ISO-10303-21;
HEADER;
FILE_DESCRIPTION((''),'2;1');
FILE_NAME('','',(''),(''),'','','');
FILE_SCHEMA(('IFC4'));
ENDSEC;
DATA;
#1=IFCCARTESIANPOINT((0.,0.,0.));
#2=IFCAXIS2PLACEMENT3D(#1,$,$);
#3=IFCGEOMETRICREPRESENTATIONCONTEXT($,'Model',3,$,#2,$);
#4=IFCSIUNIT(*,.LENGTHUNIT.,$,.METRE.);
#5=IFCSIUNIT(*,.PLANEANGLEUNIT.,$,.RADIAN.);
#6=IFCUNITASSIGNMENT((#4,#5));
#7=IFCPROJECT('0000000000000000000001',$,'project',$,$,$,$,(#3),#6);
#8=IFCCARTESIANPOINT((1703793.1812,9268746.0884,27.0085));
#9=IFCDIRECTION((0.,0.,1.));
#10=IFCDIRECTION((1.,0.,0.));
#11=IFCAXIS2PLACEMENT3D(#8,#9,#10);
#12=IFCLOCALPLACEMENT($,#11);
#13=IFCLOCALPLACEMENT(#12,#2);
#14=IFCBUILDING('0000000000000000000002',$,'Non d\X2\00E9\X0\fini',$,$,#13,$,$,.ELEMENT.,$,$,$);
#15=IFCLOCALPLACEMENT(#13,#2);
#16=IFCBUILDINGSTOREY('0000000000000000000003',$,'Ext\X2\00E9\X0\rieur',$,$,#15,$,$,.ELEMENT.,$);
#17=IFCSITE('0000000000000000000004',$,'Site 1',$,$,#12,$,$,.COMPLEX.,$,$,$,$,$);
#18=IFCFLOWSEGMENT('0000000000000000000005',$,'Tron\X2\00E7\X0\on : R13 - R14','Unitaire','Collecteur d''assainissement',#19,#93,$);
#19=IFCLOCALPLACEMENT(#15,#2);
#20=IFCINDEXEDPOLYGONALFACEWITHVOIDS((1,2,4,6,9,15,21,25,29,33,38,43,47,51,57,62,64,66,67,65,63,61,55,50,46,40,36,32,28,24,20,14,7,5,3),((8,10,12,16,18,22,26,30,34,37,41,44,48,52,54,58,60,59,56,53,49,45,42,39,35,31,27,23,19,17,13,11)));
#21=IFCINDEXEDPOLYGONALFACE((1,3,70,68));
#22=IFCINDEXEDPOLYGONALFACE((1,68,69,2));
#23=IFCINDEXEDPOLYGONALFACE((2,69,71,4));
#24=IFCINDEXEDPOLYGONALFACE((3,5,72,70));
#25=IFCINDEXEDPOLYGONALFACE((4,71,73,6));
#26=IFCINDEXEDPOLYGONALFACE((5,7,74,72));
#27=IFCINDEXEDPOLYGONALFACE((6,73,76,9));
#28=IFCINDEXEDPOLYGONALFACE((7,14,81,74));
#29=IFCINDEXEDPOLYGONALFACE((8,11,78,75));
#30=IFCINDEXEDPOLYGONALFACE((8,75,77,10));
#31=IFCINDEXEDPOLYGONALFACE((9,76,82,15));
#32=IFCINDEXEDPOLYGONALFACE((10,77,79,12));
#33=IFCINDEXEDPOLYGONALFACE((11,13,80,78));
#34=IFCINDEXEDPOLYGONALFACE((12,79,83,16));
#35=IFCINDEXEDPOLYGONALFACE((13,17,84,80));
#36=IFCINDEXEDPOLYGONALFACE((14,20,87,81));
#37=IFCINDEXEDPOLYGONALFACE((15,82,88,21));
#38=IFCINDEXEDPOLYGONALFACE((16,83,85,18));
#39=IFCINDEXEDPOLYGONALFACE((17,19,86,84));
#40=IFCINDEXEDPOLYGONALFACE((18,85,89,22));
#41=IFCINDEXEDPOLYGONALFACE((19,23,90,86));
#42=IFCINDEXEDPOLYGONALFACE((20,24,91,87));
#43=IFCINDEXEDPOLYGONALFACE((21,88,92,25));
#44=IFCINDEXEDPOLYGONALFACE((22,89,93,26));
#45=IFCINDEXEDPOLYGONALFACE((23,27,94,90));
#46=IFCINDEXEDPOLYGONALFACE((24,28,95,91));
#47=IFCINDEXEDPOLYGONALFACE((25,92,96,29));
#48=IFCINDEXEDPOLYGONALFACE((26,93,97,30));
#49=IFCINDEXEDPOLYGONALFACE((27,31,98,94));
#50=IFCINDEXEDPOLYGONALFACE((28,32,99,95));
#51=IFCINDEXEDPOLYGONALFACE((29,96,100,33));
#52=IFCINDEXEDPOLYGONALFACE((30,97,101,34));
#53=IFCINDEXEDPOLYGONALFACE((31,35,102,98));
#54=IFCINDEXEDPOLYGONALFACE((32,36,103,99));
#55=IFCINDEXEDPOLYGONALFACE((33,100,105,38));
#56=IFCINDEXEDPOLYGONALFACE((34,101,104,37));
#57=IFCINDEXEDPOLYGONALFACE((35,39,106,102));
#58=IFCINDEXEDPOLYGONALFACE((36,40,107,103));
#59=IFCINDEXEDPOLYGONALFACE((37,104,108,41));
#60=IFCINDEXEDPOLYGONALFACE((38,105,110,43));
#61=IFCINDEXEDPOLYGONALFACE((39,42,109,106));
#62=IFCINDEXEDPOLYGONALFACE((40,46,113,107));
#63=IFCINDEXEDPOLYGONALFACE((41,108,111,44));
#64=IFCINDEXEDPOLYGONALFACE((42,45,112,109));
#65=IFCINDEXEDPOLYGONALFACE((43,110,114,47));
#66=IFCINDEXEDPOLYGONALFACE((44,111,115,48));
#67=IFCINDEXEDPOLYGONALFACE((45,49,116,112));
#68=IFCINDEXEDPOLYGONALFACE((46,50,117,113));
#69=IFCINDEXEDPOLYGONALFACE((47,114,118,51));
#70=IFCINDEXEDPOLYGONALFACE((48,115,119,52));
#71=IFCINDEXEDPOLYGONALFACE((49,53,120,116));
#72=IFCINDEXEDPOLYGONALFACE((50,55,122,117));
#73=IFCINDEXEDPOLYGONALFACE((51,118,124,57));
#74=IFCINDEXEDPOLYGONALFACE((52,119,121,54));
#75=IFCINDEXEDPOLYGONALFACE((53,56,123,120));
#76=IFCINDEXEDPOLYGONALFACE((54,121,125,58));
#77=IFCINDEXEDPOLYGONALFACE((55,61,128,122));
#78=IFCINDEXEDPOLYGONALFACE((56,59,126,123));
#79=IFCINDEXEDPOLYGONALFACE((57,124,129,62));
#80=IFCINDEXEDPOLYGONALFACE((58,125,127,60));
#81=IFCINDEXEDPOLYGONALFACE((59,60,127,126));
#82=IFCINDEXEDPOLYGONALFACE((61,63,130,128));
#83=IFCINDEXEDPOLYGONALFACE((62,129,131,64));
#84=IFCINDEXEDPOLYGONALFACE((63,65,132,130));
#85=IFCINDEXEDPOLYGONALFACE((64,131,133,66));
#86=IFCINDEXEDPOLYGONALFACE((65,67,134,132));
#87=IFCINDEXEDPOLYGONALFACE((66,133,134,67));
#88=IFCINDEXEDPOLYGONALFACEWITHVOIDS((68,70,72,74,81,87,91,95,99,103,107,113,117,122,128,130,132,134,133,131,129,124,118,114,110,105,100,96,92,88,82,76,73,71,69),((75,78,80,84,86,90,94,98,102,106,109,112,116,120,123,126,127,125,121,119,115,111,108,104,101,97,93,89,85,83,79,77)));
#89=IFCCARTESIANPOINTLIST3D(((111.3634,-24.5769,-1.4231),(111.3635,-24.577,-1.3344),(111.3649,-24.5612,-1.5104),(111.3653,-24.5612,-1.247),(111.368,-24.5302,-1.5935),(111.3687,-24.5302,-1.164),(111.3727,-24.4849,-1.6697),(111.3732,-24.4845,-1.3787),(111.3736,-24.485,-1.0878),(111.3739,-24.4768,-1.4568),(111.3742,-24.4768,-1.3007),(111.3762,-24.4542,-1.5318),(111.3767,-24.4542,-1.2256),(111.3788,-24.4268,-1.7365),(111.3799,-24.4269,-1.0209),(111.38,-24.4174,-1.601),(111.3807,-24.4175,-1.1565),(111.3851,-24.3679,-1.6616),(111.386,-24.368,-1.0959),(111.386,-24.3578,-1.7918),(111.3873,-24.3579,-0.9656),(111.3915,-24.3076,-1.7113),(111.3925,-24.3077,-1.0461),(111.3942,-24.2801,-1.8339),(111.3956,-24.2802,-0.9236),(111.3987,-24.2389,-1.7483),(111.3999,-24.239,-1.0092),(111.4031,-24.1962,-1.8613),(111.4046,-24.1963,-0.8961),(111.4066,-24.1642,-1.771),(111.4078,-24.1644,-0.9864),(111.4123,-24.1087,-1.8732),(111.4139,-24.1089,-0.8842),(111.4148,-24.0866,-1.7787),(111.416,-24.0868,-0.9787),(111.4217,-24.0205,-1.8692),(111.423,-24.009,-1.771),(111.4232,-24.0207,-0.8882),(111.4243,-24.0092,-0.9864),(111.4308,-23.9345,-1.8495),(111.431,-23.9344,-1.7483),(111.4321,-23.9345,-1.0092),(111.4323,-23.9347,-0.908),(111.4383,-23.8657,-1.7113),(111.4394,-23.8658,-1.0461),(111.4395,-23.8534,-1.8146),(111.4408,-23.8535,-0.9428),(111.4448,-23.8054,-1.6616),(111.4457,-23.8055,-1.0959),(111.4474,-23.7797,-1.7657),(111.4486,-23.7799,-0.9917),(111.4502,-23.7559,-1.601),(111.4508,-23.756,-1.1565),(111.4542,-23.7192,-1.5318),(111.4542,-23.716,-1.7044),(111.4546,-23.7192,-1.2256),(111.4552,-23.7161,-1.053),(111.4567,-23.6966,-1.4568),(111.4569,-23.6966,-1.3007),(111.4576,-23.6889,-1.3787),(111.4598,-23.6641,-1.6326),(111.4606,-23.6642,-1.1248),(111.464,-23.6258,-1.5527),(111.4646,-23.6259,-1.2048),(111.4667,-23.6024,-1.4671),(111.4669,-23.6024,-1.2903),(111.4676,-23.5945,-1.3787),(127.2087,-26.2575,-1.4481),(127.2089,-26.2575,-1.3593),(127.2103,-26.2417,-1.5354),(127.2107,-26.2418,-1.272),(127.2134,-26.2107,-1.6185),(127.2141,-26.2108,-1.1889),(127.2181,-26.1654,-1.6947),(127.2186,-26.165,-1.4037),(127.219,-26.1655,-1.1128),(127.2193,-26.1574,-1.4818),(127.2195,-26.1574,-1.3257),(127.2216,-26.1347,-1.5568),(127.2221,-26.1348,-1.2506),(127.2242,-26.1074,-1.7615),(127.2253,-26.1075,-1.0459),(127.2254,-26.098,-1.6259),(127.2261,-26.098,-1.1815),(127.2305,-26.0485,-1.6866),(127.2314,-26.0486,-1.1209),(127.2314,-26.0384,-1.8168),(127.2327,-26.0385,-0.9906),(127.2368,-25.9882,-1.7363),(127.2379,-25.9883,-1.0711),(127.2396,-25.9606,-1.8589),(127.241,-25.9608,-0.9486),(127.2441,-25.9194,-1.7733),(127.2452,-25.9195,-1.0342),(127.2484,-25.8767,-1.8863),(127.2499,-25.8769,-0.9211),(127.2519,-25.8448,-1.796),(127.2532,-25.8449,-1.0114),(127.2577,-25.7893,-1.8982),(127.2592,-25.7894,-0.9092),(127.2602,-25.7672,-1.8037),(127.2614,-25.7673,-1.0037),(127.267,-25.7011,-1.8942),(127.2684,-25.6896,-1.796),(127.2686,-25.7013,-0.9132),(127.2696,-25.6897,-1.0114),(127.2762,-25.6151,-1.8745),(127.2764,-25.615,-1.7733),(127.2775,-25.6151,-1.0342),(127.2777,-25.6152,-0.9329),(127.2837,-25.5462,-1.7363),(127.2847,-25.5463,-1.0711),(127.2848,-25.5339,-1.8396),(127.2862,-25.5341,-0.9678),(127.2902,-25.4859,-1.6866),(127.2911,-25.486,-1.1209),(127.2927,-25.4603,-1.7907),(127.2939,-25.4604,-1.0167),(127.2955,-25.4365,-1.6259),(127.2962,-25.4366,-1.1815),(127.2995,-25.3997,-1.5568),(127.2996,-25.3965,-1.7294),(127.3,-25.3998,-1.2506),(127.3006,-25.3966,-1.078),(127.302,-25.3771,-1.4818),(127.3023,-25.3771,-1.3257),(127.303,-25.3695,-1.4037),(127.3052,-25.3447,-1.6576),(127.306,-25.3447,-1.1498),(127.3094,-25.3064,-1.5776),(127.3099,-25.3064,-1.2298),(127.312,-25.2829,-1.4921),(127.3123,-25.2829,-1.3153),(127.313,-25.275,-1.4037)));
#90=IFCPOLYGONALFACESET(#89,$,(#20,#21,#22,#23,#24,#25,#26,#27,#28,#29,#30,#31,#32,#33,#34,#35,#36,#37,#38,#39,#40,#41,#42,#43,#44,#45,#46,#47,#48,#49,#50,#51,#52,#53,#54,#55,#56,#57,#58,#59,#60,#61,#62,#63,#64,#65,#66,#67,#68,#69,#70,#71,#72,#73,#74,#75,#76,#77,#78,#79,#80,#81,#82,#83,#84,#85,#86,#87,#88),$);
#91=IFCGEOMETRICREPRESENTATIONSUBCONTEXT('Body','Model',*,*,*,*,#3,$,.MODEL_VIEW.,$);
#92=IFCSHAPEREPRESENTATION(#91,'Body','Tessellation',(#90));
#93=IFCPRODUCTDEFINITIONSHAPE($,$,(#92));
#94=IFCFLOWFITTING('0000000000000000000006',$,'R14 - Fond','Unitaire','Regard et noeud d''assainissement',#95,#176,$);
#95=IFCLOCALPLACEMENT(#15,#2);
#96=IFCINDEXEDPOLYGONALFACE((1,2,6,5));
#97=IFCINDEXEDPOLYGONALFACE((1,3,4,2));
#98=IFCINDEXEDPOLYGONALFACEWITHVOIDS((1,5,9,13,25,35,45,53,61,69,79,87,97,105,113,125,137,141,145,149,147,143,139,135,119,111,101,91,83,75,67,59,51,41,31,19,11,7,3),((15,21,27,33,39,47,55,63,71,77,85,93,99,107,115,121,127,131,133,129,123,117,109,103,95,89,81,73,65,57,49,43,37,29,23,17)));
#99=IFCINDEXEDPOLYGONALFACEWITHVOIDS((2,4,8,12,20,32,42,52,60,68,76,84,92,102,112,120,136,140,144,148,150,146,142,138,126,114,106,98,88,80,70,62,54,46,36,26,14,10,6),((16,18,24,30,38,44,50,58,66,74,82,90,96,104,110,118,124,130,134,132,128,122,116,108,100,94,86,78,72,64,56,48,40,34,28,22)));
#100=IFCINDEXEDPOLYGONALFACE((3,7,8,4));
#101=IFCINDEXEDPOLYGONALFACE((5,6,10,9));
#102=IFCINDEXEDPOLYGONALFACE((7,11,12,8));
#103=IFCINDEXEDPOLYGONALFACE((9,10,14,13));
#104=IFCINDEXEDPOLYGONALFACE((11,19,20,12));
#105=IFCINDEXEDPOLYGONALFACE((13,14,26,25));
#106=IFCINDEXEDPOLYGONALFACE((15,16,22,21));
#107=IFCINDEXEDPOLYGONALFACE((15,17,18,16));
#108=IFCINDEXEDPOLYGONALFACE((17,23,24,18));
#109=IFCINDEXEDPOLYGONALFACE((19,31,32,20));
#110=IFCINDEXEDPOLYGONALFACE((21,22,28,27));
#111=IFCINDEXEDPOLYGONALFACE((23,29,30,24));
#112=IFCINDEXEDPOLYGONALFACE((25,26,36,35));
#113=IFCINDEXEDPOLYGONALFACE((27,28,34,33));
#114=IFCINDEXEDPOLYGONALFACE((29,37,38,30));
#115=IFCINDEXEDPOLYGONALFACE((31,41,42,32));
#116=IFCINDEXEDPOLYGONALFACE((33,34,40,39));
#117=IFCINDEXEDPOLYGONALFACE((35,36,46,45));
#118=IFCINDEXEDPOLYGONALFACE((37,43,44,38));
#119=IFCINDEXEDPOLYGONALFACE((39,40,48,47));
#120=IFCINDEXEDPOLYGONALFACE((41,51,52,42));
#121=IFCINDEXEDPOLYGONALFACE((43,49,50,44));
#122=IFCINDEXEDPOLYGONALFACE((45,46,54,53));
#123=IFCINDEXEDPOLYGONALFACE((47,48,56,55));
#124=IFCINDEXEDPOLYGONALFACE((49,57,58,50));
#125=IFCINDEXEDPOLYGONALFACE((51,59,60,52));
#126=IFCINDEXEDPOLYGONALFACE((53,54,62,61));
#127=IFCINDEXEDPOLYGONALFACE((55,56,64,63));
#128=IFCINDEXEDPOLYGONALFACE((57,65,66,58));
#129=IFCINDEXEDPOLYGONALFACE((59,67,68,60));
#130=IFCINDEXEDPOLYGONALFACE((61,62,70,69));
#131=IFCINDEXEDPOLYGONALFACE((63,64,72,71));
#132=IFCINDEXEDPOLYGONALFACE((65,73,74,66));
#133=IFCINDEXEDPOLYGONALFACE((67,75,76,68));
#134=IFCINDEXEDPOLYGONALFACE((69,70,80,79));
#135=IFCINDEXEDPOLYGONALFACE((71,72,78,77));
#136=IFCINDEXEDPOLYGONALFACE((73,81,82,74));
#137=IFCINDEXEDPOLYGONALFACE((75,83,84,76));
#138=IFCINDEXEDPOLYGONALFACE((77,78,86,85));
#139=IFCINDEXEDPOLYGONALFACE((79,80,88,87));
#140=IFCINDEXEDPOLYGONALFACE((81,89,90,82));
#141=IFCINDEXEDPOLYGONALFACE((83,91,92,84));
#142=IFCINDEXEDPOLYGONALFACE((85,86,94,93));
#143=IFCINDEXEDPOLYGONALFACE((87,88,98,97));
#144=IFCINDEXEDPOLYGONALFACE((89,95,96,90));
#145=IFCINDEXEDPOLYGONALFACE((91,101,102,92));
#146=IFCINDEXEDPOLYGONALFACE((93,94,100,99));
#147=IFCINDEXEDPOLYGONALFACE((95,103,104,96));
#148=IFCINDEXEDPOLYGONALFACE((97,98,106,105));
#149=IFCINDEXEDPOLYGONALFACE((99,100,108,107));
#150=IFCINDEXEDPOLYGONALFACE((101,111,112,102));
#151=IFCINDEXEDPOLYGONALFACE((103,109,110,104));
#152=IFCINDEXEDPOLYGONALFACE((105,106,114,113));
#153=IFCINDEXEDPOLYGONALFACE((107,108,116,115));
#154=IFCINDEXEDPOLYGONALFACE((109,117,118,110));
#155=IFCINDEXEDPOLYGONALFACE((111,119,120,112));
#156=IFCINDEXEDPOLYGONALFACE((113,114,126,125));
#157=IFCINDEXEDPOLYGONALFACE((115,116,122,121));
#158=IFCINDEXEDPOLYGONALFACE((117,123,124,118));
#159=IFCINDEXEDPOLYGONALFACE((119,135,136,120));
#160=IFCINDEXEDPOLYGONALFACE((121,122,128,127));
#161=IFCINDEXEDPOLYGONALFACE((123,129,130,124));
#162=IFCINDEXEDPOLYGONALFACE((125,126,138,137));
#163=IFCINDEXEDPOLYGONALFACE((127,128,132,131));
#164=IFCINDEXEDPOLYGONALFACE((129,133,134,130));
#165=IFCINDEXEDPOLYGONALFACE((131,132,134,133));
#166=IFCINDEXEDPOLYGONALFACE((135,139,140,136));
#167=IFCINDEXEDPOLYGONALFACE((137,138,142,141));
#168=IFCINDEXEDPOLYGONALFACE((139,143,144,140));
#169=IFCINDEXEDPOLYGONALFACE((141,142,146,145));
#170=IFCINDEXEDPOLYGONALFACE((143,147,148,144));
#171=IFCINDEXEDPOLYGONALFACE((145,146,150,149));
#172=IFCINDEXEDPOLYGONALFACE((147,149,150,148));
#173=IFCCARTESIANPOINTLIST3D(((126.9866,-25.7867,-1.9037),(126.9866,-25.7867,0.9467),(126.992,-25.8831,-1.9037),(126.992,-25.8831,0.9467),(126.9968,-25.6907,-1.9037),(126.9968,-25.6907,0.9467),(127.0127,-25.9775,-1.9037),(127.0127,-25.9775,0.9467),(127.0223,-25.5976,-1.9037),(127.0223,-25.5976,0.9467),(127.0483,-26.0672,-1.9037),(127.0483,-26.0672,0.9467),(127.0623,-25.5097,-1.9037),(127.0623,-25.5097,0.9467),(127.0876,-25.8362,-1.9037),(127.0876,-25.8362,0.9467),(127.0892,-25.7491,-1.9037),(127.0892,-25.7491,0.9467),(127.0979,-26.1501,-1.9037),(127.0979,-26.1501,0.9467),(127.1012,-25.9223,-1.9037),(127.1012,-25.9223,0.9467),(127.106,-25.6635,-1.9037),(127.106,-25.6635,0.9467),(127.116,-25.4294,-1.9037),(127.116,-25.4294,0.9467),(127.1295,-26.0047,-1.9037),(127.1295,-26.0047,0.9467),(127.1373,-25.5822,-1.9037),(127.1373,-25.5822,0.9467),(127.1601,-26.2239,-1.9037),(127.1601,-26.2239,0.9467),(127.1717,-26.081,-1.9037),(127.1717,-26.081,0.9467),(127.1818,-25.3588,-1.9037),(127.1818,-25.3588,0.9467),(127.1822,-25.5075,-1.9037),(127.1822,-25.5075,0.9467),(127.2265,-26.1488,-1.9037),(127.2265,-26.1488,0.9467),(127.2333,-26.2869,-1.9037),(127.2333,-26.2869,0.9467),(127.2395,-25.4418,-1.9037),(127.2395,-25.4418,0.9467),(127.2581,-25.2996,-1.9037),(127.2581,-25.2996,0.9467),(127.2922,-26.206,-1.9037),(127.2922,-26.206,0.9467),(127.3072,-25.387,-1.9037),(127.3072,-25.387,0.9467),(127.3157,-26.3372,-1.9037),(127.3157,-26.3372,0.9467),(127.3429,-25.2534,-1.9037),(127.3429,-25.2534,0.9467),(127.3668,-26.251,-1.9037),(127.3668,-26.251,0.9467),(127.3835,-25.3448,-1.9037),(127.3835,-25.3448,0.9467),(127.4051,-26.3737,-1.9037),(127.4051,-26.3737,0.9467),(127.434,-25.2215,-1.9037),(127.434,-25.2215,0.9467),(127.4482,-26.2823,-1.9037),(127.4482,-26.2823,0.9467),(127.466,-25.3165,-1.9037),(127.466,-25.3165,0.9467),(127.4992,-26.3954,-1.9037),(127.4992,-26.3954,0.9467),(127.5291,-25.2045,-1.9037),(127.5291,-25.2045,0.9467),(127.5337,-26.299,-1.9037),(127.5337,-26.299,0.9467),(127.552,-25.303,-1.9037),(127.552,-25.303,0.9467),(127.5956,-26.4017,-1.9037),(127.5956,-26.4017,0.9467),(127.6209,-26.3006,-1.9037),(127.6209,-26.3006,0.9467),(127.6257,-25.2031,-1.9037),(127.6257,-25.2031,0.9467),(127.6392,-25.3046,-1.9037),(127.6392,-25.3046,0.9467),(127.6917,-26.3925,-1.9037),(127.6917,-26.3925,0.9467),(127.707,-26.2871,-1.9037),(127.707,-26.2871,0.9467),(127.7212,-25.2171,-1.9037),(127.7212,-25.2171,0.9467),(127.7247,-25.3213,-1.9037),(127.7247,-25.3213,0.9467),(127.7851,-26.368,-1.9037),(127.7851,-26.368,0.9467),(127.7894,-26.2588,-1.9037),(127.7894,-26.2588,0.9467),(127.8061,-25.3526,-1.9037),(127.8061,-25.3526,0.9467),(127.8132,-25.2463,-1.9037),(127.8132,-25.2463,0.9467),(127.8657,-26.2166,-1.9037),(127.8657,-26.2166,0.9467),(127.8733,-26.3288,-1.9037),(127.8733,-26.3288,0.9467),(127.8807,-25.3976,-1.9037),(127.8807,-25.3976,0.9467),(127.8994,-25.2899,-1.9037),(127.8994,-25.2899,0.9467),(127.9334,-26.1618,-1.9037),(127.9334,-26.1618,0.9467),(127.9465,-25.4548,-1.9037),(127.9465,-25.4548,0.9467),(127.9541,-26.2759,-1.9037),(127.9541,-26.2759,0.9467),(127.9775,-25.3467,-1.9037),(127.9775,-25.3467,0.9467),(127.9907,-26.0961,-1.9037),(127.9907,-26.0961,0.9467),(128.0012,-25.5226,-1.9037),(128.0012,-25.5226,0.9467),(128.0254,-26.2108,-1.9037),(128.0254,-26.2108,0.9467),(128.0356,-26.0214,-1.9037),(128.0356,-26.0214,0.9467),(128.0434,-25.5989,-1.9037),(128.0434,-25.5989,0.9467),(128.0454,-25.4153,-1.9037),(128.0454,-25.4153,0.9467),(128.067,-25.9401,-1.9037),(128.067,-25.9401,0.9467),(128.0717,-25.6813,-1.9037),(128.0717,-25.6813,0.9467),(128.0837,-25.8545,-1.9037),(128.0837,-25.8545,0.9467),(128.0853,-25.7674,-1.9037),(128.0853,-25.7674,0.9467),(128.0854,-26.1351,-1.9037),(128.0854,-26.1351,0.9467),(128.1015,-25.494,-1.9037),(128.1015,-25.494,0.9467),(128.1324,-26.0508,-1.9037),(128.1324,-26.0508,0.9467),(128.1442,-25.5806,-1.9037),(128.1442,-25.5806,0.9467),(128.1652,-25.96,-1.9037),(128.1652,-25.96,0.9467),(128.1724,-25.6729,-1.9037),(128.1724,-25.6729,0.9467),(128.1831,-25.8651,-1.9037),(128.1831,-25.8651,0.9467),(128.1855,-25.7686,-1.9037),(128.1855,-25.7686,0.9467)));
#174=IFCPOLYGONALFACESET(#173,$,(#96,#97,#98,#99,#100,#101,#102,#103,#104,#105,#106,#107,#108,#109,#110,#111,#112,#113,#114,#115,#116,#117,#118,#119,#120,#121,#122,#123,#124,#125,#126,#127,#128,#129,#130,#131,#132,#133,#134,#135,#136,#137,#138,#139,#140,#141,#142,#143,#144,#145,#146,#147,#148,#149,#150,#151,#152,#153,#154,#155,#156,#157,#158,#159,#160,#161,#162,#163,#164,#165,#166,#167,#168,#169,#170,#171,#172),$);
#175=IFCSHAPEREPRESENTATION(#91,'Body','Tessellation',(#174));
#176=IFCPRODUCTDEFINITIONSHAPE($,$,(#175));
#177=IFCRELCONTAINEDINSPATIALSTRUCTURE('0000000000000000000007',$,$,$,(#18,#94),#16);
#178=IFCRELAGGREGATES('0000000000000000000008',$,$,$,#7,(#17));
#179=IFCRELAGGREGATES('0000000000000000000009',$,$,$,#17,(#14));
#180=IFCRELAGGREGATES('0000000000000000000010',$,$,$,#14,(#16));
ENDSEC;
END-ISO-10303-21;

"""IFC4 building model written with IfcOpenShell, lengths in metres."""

from ifc_helpers import new_model, si_unit, frame, origin, origin_2d, place, context, subcontext, project, spatial, hollow_circle, extrude, element, save


model = new_model("IFC4")

# Units and contexts
model_context = context("Model", 3, world=origin())
body_context = subcontext(model_context, "Body", "Model", "MODEL_VIEW")
ifc_project = project(units=[si_unit("LENGTHUNIT", "METRE"), si_unit("PLANEANGLEUNIT", "RADIAN")], contexts=[model_context])

# Site, building, storey
site_placement = place(None, frame((1703793.1812, 9268746.0884, 27.0085), z_axis=(0.0, 0.0, 1.0), x_axis=(1.0, 0.0, 0.0)))
site = spatial("IfcSite", under=ifc_project, at=site_placement, Name="Site 1", CompositionType="COMPLEX")
building_placement = place(site_placement, origin())
building = spatial("IfcBuilding", under=site, at=building_placement, Name="Non défini", CompositionType="ELEMENT")
storey_placement = place(building_placement, origin())
storey = spatial("IfcBuildingStorey", under=building, at=storey_placement, Name="Extérieur", CompositionType="ELEMENT")

# Flow segment
flow_segment_1_placement = place(storey_placement, origin())
element("IfcFlowSegment", 1, at=flow_segment_1_placement, inside=storey, Name="Tronçon : R13 - R14", Description="Unitaire", ObjectType="Collecteur d'assainissement", context=body_context, shape_type="SweptSolid", body=[
    extrude(hollow_circle(Radius=0.495, WallThickness=0.095, at=origin_2d()), frame((111.4154, -24.0867, -1.3787), z_axis=(0.994421, -0.105468, -0.001569), x_axis=(0.105469, 0.994423, 0.0)), (0.0, 0.0, 1.0), 15.9343),
])

# Flow fitting
flow_fitting_1_placement = place(storey_placement, origin())
element("IfcFlowFitting", 2, at=flow_fitting_1_placement, inside=storey, Name="R14 - Fond", Description="Unitaire", ObjectType="Regard et noeud d'assainissement", context=body_context, shape_type="SweptSolid", body=[
    extrude(hollow_circle(Radius=0.6, WallThickness=0.1, at=origin_2d()), frame((127.5865, -25.8018, -1.9037), z_axis=(0.0, 0.0, 1.0), x_axis=(0.994423, -0.105469, 0.0)), (0.0, 0.0, 1.0), 2.8504),
])

save(model, "model.ifc")
